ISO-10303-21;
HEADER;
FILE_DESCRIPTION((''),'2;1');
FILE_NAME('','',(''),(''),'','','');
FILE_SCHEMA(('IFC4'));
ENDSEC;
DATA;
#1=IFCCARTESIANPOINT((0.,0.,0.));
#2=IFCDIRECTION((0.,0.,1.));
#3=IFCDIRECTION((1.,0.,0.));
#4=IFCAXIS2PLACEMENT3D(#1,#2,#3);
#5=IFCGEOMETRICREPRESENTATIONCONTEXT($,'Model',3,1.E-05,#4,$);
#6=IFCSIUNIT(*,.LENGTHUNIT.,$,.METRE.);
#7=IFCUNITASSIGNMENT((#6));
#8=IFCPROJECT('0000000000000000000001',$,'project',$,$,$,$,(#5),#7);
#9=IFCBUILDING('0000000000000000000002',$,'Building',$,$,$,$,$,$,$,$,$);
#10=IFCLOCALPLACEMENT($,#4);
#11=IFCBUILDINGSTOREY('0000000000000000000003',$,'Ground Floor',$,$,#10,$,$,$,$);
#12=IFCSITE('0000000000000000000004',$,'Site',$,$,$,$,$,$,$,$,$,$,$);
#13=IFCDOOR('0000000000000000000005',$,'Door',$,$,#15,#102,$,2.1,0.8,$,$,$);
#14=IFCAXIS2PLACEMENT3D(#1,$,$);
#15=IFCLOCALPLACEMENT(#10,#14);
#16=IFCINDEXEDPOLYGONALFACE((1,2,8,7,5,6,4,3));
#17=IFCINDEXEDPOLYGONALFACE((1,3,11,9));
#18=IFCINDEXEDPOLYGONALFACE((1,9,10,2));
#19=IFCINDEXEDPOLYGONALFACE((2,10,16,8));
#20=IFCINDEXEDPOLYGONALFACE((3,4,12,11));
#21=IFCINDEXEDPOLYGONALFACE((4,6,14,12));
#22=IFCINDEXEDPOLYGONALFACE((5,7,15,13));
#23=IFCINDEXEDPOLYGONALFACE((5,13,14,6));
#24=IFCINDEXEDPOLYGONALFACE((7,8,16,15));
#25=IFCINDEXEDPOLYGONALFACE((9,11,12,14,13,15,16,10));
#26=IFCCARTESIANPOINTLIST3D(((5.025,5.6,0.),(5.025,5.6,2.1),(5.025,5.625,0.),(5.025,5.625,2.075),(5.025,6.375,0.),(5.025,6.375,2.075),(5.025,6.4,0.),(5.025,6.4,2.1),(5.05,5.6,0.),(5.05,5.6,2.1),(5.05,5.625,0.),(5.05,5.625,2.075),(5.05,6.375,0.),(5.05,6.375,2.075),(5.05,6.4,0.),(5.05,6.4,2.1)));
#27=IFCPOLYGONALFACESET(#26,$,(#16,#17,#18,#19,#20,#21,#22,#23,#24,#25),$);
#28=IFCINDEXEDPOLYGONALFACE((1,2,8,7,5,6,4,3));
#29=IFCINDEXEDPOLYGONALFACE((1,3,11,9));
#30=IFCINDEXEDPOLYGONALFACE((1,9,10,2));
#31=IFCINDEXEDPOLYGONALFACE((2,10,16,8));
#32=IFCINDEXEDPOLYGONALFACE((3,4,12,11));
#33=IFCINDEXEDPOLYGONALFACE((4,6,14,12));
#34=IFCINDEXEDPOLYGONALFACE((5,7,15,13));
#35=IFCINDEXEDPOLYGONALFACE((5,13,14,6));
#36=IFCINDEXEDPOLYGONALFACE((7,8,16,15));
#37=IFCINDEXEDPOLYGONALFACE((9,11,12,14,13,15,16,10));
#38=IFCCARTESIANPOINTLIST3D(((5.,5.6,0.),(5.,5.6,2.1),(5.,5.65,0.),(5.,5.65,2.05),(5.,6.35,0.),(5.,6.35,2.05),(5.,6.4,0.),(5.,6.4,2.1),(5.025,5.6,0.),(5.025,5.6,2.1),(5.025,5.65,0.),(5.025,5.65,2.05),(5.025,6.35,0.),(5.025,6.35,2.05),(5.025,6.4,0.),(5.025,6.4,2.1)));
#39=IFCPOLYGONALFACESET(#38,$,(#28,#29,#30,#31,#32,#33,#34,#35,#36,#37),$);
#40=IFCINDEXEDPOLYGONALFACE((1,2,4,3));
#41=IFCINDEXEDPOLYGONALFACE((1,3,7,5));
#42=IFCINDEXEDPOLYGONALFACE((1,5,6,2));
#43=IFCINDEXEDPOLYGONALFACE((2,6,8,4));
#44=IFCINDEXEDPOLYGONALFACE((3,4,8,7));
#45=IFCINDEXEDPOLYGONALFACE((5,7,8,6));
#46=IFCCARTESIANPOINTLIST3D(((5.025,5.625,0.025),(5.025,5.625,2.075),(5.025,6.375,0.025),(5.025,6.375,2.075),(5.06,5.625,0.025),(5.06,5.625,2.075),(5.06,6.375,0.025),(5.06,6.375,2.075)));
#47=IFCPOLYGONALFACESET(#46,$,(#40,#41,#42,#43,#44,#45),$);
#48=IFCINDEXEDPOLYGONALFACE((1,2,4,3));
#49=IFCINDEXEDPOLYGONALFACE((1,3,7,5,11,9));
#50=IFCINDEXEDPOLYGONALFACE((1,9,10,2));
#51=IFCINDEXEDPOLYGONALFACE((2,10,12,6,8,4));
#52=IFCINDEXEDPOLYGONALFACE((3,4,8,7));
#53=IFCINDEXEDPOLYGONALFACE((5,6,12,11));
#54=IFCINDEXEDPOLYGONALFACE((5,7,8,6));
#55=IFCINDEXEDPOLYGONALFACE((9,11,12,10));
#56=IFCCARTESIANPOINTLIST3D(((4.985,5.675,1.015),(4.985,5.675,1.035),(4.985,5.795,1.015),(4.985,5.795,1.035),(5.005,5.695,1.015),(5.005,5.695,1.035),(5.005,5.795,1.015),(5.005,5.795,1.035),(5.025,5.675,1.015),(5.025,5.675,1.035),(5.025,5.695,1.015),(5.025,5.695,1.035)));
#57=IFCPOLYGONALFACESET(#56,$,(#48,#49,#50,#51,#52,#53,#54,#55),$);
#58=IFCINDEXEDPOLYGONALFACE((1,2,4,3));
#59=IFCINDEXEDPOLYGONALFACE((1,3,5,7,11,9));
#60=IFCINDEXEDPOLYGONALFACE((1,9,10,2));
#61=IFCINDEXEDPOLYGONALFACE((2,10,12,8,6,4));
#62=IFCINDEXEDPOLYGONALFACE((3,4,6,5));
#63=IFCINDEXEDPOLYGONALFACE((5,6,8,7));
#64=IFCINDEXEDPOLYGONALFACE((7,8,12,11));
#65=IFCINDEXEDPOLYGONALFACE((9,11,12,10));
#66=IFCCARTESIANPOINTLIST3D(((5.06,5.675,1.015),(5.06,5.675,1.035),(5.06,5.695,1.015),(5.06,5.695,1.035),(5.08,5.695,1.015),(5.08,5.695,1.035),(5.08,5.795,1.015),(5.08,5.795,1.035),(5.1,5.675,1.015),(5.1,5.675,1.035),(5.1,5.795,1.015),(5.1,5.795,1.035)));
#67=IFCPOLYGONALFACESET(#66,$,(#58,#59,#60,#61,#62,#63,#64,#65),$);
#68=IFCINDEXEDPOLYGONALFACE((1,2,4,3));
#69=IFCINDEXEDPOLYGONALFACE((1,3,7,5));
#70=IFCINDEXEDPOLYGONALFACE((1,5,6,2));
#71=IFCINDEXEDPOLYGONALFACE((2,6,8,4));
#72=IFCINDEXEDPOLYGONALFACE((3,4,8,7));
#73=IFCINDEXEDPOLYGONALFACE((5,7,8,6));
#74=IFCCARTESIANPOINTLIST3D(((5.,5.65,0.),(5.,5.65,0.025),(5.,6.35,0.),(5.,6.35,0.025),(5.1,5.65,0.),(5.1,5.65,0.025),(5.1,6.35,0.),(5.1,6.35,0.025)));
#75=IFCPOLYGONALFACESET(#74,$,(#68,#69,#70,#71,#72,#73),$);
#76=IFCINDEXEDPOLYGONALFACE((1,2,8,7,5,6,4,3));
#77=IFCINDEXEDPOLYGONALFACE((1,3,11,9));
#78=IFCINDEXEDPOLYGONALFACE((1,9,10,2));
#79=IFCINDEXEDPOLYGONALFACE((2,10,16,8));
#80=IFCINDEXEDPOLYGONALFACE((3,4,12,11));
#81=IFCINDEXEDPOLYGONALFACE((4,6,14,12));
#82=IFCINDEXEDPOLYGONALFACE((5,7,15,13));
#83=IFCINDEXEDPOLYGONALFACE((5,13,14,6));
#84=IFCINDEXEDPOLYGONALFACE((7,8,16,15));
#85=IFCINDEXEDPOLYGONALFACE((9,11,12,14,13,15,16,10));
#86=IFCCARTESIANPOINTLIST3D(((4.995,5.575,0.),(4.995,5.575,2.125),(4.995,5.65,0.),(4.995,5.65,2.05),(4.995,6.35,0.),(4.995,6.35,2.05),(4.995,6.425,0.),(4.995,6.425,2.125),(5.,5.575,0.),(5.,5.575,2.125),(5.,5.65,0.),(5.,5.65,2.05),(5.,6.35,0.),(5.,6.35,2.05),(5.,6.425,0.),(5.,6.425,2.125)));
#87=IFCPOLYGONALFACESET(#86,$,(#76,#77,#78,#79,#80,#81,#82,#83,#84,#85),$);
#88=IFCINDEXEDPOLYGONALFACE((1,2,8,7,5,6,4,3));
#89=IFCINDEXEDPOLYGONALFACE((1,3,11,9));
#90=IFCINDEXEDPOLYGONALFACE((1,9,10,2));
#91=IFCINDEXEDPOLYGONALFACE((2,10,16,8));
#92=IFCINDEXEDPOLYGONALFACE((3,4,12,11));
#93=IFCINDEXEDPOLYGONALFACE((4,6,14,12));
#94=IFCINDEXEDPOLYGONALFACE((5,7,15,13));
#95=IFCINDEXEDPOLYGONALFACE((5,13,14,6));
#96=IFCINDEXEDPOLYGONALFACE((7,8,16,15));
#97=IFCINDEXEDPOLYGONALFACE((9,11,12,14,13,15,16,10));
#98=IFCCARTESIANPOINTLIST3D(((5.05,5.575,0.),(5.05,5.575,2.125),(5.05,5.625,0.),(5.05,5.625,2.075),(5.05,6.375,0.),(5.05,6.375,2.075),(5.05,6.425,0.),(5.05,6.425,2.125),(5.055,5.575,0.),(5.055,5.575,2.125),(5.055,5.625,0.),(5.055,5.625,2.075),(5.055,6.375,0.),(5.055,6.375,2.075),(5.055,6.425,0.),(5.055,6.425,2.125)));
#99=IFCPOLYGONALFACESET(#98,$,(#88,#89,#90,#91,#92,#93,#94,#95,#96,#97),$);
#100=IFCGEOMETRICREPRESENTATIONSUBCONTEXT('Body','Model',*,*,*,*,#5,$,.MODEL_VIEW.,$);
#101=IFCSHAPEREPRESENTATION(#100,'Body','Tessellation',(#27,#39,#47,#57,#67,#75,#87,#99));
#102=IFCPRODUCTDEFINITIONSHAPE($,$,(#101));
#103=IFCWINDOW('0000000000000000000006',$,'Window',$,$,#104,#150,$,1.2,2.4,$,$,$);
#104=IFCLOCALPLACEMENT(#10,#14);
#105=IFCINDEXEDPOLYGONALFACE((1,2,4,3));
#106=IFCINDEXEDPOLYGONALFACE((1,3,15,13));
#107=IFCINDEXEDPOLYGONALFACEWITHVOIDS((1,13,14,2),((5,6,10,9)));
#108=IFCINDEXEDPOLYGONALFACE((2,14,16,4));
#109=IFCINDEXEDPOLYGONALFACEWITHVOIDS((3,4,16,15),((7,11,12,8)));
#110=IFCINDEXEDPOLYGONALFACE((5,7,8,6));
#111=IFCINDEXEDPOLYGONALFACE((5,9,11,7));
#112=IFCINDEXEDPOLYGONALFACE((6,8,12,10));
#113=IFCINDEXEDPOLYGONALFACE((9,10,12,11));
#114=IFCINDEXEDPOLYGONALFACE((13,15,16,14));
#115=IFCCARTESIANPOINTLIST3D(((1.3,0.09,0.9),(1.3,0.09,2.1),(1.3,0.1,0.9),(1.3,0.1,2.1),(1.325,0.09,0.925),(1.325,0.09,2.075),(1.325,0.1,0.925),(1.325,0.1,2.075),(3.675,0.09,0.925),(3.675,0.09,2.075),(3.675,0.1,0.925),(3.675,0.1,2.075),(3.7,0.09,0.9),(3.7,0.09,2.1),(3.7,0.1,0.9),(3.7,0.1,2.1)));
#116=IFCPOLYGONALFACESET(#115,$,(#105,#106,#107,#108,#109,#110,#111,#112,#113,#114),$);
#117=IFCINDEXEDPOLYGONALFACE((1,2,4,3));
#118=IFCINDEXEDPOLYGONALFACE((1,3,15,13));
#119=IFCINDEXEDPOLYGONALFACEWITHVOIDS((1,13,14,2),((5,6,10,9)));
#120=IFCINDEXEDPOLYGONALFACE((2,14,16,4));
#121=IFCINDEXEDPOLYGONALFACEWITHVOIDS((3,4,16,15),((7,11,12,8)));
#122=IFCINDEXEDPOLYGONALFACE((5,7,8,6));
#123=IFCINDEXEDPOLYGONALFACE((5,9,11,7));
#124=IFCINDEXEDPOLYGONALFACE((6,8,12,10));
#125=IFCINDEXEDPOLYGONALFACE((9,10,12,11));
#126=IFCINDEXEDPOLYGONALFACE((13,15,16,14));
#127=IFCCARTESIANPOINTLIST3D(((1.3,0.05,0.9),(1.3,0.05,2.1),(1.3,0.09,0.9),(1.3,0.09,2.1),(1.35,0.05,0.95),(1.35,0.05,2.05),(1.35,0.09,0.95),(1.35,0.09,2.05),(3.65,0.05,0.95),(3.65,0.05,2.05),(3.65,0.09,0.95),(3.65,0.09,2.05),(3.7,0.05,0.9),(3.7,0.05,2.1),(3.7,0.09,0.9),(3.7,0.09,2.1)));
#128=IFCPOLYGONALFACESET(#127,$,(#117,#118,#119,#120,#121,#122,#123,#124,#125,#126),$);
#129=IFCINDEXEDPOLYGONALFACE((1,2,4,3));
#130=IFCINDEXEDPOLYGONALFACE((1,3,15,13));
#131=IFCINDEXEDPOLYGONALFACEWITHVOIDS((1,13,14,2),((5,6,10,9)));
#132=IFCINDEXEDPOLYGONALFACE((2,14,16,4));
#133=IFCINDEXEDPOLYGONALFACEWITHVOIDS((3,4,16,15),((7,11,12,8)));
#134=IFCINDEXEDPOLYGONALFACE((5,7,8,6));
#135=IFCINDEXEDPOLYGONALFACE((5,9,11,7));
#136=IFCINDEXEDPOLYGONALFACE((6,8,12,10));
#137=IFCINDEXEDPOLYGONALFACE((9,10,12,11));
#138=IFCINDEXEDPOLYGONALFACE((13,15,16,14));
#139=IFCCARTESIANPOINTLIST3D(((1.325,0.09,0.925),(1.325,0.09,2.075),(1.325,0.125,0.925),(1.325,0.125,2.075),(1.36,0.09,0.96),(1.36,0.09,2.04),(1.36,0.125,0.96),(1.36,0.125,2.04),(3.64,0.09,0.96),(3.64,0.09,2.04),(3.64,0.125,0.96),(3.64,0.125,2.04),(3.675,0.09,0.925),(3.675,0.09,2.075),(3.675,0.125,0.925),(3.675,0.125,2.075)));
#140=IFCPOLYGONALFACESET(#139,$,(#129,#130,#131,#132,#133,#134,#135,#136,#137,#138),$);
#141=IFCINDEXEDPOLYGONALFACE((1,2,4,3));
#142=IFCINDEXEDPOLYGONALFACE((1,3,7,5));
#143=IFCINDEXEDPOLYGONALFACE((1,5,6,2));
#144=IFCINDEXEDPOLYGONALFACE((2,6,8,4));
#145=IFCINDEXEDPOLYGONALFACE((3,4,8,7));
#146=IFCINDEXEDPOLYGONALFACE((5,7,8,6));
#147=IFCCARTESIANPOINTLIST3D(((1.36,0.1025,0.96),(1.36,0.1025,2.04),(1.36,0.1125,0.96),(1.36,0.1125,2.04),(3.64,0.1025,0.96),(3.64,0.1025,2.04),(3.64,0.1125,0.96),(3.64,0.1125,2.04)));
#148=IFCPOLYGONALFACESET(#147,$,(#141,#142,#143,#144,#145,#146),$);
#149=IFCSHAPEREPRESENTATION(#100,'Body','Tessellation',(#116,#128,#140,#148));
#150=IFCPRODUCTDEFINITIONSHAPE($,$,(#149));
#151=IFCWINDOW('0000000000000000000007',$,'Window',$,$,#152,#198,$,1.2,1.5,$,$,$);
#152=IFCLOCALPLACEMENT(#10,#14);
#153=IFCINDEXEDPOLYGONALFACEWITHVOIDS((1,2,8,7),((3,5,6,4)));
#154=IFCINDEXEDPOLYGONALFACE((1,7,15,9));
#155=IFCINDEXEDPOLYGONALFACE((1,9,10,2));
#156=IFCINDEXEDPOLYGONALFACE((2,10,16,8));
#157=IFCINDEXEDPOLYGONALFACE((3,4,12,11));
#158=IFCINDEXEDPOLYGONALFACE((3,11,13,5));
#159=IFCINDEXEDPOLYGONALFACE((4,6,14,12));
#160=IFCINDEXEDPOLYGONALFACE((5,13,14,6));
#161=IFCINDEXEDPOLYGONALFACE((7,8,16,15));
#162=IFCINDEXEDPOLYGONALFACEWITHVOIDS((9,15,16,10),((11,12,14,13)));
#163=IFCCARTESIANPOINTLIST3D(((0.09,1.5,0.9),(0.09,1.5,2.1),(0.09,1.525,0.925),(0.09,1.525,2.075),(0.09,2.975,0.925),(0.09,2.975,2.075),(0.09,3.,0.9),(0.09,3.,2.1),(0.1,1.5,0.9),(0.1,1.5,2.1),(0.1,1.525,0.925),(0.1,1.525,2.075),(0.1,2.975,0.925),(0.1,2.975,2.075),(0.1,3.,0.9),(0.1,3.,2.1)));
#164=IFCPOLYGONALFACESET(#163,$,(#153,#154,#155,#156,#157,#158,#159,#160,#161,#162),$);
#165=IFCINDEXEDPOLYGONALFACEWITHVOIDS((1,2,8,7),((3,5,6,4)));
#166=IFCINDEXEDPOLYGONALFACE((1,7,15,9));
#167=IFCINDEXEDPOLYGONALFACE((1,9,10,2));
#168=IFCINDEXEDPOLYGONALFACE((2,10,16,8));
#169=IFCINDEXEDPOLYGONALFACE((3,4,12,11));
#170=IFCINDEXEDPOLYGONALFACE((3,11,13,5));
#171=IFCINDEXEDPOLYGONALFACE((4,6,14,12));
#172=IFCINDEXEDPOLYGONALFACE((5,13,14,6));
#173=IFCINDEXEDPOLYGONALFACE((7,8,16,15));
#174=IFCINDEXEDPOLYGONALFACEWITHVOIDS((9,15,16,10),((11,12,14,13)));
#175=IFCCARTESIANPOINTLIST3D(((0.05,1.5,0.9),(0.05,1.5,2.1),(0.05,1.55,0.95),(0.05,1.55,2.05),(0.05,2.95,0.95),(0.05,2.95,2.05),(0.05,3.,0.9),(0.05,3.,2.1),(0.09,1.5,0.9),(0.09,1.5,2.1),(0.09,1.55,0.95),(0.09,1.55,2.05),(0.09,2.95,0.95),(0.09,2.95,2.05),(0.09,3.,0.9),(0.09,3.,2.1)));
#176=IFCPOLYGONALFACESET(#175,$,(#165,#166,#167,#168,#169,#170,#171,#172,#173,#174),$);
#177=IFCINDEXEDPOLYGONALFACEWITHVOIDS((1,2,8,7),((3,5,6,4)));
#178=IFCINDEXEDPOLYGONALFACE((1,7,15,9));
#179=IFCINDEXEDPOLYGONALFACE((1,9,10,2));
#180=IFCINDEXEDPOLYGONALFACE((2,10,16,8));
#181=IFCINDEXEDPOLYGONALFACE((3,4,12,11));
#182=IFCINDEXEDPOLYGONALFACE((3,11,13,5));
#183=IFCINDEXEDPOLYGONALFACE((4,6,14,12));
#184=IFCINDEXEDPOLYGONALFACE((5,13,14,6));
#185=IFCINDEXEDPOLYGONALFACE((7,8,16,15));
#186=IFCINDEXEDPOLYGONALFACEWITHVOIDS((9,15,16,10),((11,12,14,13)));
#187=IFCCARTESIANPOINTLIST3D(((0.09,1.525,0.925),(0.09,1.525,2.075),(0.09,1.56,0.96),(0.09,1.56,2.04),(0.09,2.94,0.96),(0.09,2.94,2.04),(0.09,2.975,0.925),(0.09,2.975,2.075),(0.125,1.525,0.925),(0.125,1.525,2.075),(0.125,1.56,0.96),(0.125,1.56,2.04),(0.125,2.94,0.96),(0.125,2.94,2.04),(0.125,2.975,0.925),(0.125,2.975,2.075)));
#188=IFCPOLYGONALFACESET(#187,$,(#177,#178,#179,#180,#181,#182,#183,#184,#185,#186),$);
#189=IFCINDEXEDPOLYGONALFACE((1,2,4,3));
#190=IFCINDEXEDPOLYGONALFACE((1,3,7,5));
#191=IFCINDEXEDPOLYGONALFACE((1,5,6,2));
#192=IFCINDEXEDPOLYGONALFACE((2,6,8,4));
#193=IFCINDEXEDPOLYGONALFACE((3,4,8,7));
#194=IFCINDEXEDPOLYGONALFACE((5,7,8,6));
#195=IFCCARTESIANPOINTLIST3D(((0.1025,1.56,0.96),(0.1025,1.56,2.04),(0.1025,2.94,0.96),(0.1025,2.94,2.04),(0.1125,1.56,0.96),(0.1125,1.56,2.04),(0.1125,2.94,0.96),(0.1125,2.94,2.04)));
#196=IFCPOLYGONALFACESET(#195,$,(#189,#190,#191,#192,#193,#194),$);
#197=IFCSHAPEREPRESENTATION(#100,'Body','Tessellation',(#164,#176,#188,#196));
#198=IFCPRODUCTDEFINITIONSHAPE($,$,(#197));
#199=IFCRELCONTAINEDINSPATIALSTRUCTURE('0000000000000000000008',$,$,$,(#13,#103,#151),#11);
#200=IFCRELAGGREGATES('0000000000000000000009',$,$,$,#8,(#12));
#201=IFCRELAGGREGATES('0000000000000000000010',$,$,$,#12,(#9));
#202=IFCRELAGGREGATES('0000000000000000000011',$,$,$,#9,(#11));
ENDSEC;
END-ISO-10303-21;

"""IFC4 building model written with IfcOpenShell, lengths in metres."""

from ifc_helpers import new_model, si_unit, frame, origin_with_axes, place, context, subcontext, project, spatial, line, indexed_curve, outline, extrude, element, save


model = new_model("IFC4")

# Units and contexts
model_context = context("Model", 3, precision=1e-05, world=origin_with_axes())
body_context = subcontext(model_context, "Body", "Model", "MODEL_VIEW")
ifc_project = project(units=[si_unit("LENGTHUNIT", "METRE")], contexts=[model_context])

# Site, building, storey
site = spatial("IfcSite", under=ifc_project, Name="Site")
building = spatial("IfcBuilding", under=site, Name="Building")
storey_placement = place(None, origin_with_axes())
storey = spatial("IfcBuildingStorey", under=building, at=storey_placement, Name="Ground Floor")

# Door
door_1_placement = place(storey_placement, frame((5.0, 6.4, 0.0), z_axis=(0.0, 0.0, 1.0), x_axis=(0.0, -1.0, 0.0)))
element("IfcDoor", 1, at=door_1_placement, inside=storey, Name="Door", OverallHeight=2.1, OverallWidth=0.8, context=body_context, shape_type="SweptSolid", body=[
    extrude(outline(indexed_curve([(0.0, 0.0), (0.0, 2.1), (0.8, 2.1), (0.8, 0.0), (0.775, 0.0), (0.775, 2.075), (0.025, 2.075), (0.025, 0.0)], segments=[line(1, 2, 3, 4, 5, 6, 7, 8, 1)])), frame((0.0, 0.025, 0.0), z_axis=(0.0, -1.0, 0.0), x_axis=(1.0, 0.0, 0.0)), (0.0, 0.0, -1.0), 0.025),
    extrude(outline(indexed_curve([(0.0, 0.0), (0.0, 2.1), (0.8, 2.1), (0.8, 0.0), (0.75, 0.0), (0.75, 2.05), (0.05, 2.05), (0.05, 0.0)], segments=[line(1, 2, 3, 4, 5, 6, 7, 8, 1)])), frame((0.0, 0.0, 0.0), z_axis=(0.0, -1.0, 0.0), x_axis=(1.0, 0.0, 0.0)), (0.0, 0.0, -1.0), 0.025),
    extrude(outline(indexed_curve([(0.0, 0.0), (0.75, 0.0), (0.75, 0.035), (0.0, 0.035)], segments=[line(1, 2, 3, 4, 1)])), frame((0.025, 0.025, 0.025), z_axis=(0.0, 0.0, 1.0), x_axis=(1.0, 0.0, 0.0)), (0.0, 0.0, 1.0), 2.05),
    extrude(outline(indexed_curve([(0.0, 0.0), (0.0, -0.04), (-0.12, -0.04), (-0.12, -0.02), (-0.02, -0.02), (-0.02, 0.0)], segments=[line(1, 2, 3, 4, 5, 6, 1)])), frame((0.725, 0.025, 1.015), z_axis=(0.0, 0.0, 1.0), x_axis=(1.0, 0.0, 0.0)), (0.0, 0.0, 1.0), 0.02),
    extrude(outline(indexed_curve([(0.0, 0.0), (0.0, 0.04), (-0.12, 0.04), (-0.12, 0.02), (-0.02, 0.02), (-0.02, 0.0)], segments=[line(1, 2, 3, 4, 5, 6, 1)])), frame((0.725, 0.06, 1.015), z_axis=(0.0, 0.0, 1.0), x_axis=(1.0, 0.0, 0.0)), (0.0, 0.0, 1.0), 0.02),
    extrude(outline(indexed_curve([(0.0, 0.0), (0.7, 0.0), (0.7, 0.1), (0.0, 0.1)], segments=[line(1, 2, 3, 4, 1)])), frame((0.05, 0.0, 0.0), z_axis=(0.0, 0.0, 1.0), x_axis=(1.0, 0.0, 0.0)), (0.0, 0.0, 1.0), 0.025),
    extrude(outline(indexed_curve([(0.0, 0.0), (0.0, 2.125), (0.85, 2.125), (0.85, 0.0), (0.775, 0.0), (0.775, 2.05), (0.075, 2.05), (0.075, 0.0)], segments=[line(1, 2, 3, 4, 5, 6, 7, 8, 1)])), frame((-0.025, -0.005, 0.0), z_axis=(0.0, -1.0, 0.0), x_axis=(1.0, 0.0, 0.0)), (0.0, 0.0, -1.0), 0.005),
    extrude(outline(indexed_curve([(0.0, 0.0), (0.0, 2.125), (0.85, 2.125), (0.85, 0.0), (0.8, 0.0), (0.8, 2.075), (0.05, 2.075), (0.05, 0.0)], segments=[line(1, 2, 3, 4, 5, 6, 7, 8, 1)])), frame((-0.025, 0.05, 0.0), z_axis=(0.0, -1.0, 0.0), x_axis=(1.0, 0.0, 0.0)), (0.0, 0.0, -1.0), 0.005),
])

# Windows
window_1_placement = place(storey_placement, frame((1.3, 0.0, 0.9), z_axis=(0.0, 0.0, 1.0), x_axis=(1.0, 0.0, 0.0)))
element("IfcWindow", 2, at=window_1_placement, inside=storey, Name="Window", OverallHeight=1.2, OverallWidth=2.4, context=body_context, shape_type="SweptSolid", body=[
    extrude(outline(indexed_curve([(0.0, 0.0), (2.4, 0.0), (2.4, 1.2), (0.0, 1.2)], segments=[line(1, 2, 3, 4, 1)]), holes=[indexed_curve([(0.025, 0.025), (2.375, 0.025), (2.375, 1.175), (0.025, 1.175)], segments=[line(1, 2, 3, 4, 1)])]), frame((0.0, 0.09, 0.0), z_axis=(0.0, -1.0, 0.0), x_axis=(1.0, 0.0, 0.0)), (0.0, 0.0, -1.0), 0.01),
    extrude(outline(indexed_curve([(0.0, 0.0), (2.4, 0.0), (2.4, 1.2), (0.0, 1.2)], segments=[line(1, 2, 3, 4, 1)]), holes=[indexed_curve([(0.05, 0.05), (2.35, 0.05), (2.35, 1.15), (0.05, 1.15)], segments=[line(1, 2, 3, 4, 1)])]), frame((0.0, 0.05, 0.0), z_axis=(0.0, -1.0, 0.0), x_axis=(1.0, 0.0, 0.0)), (0.0, 0.0, -1.0), 0.04),
    extrude(outline(indexed_curve([(0.0, 0.0), (2.35, 0.0), (2.35, 1.15), (0.0, 1.15)], segments=[line(1, 2, 3, 4, 1)]), holes=[indexed_curve([(0.035, 0.035), (2.315, 0.035), (2.315, 1.115), (0.035, 1.115)], segments=[line(1, 2, 3, 4, 1)])]), frame((0.025, 0.09, 0.025), z_axis=(0.0, -1.0, 0.0), x_axis=(1.0, 0.0, 0.0)), (0.0, 0.0, -1.0), 0.035),
    extrude(outline(indexed_curve([(0.035, 0.035), (2.315, 0.035), (2.315, 1.115), (0.035, 1.115)], segments=[line(1, 2, 3, 4, 1)])), frame((0.025, 0.1025, 0.025), z_axis=(0.0, -1.0, 0.0), x_axis=(1.0, 0.0, 0.0)), (0.0, 0.0, -1.0), 0.01),
])
for number, where, z_axis, x_axis, name in (
    (3, (0.0, 3.0, 0.9), (0.0, 0.0, 1.0), (0.0, -1.0, 0.0), "Window"),
):
    element("IfcWindow", number, at=place(storey_placement, frame(where, z_axis=z_axis, x_axis=x_axis)), inside=storey, Name=name, OverallHeight=1.2, OverallWidth=1.5, context=body_context, shape_type="SweptSolid", body=[
        extrude(outline(indexed_curve([(0.0, 0.0), (1.5, 0.0), (1.5, 1.2), (0.0, 1.2)], segments=[line(1, 2, 3, 4, 1)]), holes=[indexed_curve([(0.025, 0.025), (1.475, 0.025), (1.475, 1.175), (0.025, 1.175)], segments=[line(1, 2, 3, 4, 1)])]), frame((0.0, 0.09, 0.0), z_axis=(0.0, -1.0, 0.0), x_axis=(1.0, 0.0, 0.0)), (0.0, 0.0, -1.0), 0.01),
        extrude(outline(indexed_curve([(0.0, 0.0), (1.5, 0.0), (1.5, 1.2), (0.0, 1.2)], segments=[line(1, 2, 3, 4, 1)]), holes=[indexed_curve([(0.05, 0.05), (1.45, 0.05), (1.45, 1.15), (0.05, 1.15)], segments=[line(1, 2, 3, 4, 1)])]), frame((0.0, 0.05, 0.0), z_axis=(0.0, -1.0, 0.0), x_axis=(1.0, 0.0, 0.0)), (0.0, 0.0, -1.0), 0.04),
        extrude(outline(indexed_curve([(0.0, 0.0), (1.45, 0.0), (1.45, 1.15), (0.0, 1.15)], segments=[line(1, 2, 3, 4, 1)]), holes=[indexed_curve([(0.035, 0.035), (1.415, 0.035), (1.415, 1.115), (0.035, 1.115)], segments=[line(1, 2, 3, 4, 1)])]), frame((0.025, 0.09, 0.025), z_axis=(0.0, -1.0, 0.0), x_axis=(1.0, 0.0, 0.0)), (0.0, 0.0, -1.0), 0.035),
        extrude(outline(indexed_curve([(0.035, 0.035), (1.415, 0.035), (1.415, 1.115), (0.035, 1.115)], segments=[line(1, 2, 3, 4, 1)])), frame((0.025, 0.1025, 0.025), z_axis=(0.0, -1.0, 0.0), x_axis=(1.0, 0.0, 0.0)), (0.0, 0.0, -1.0), 0.01),
    ])

save(model, "model.ifc")
